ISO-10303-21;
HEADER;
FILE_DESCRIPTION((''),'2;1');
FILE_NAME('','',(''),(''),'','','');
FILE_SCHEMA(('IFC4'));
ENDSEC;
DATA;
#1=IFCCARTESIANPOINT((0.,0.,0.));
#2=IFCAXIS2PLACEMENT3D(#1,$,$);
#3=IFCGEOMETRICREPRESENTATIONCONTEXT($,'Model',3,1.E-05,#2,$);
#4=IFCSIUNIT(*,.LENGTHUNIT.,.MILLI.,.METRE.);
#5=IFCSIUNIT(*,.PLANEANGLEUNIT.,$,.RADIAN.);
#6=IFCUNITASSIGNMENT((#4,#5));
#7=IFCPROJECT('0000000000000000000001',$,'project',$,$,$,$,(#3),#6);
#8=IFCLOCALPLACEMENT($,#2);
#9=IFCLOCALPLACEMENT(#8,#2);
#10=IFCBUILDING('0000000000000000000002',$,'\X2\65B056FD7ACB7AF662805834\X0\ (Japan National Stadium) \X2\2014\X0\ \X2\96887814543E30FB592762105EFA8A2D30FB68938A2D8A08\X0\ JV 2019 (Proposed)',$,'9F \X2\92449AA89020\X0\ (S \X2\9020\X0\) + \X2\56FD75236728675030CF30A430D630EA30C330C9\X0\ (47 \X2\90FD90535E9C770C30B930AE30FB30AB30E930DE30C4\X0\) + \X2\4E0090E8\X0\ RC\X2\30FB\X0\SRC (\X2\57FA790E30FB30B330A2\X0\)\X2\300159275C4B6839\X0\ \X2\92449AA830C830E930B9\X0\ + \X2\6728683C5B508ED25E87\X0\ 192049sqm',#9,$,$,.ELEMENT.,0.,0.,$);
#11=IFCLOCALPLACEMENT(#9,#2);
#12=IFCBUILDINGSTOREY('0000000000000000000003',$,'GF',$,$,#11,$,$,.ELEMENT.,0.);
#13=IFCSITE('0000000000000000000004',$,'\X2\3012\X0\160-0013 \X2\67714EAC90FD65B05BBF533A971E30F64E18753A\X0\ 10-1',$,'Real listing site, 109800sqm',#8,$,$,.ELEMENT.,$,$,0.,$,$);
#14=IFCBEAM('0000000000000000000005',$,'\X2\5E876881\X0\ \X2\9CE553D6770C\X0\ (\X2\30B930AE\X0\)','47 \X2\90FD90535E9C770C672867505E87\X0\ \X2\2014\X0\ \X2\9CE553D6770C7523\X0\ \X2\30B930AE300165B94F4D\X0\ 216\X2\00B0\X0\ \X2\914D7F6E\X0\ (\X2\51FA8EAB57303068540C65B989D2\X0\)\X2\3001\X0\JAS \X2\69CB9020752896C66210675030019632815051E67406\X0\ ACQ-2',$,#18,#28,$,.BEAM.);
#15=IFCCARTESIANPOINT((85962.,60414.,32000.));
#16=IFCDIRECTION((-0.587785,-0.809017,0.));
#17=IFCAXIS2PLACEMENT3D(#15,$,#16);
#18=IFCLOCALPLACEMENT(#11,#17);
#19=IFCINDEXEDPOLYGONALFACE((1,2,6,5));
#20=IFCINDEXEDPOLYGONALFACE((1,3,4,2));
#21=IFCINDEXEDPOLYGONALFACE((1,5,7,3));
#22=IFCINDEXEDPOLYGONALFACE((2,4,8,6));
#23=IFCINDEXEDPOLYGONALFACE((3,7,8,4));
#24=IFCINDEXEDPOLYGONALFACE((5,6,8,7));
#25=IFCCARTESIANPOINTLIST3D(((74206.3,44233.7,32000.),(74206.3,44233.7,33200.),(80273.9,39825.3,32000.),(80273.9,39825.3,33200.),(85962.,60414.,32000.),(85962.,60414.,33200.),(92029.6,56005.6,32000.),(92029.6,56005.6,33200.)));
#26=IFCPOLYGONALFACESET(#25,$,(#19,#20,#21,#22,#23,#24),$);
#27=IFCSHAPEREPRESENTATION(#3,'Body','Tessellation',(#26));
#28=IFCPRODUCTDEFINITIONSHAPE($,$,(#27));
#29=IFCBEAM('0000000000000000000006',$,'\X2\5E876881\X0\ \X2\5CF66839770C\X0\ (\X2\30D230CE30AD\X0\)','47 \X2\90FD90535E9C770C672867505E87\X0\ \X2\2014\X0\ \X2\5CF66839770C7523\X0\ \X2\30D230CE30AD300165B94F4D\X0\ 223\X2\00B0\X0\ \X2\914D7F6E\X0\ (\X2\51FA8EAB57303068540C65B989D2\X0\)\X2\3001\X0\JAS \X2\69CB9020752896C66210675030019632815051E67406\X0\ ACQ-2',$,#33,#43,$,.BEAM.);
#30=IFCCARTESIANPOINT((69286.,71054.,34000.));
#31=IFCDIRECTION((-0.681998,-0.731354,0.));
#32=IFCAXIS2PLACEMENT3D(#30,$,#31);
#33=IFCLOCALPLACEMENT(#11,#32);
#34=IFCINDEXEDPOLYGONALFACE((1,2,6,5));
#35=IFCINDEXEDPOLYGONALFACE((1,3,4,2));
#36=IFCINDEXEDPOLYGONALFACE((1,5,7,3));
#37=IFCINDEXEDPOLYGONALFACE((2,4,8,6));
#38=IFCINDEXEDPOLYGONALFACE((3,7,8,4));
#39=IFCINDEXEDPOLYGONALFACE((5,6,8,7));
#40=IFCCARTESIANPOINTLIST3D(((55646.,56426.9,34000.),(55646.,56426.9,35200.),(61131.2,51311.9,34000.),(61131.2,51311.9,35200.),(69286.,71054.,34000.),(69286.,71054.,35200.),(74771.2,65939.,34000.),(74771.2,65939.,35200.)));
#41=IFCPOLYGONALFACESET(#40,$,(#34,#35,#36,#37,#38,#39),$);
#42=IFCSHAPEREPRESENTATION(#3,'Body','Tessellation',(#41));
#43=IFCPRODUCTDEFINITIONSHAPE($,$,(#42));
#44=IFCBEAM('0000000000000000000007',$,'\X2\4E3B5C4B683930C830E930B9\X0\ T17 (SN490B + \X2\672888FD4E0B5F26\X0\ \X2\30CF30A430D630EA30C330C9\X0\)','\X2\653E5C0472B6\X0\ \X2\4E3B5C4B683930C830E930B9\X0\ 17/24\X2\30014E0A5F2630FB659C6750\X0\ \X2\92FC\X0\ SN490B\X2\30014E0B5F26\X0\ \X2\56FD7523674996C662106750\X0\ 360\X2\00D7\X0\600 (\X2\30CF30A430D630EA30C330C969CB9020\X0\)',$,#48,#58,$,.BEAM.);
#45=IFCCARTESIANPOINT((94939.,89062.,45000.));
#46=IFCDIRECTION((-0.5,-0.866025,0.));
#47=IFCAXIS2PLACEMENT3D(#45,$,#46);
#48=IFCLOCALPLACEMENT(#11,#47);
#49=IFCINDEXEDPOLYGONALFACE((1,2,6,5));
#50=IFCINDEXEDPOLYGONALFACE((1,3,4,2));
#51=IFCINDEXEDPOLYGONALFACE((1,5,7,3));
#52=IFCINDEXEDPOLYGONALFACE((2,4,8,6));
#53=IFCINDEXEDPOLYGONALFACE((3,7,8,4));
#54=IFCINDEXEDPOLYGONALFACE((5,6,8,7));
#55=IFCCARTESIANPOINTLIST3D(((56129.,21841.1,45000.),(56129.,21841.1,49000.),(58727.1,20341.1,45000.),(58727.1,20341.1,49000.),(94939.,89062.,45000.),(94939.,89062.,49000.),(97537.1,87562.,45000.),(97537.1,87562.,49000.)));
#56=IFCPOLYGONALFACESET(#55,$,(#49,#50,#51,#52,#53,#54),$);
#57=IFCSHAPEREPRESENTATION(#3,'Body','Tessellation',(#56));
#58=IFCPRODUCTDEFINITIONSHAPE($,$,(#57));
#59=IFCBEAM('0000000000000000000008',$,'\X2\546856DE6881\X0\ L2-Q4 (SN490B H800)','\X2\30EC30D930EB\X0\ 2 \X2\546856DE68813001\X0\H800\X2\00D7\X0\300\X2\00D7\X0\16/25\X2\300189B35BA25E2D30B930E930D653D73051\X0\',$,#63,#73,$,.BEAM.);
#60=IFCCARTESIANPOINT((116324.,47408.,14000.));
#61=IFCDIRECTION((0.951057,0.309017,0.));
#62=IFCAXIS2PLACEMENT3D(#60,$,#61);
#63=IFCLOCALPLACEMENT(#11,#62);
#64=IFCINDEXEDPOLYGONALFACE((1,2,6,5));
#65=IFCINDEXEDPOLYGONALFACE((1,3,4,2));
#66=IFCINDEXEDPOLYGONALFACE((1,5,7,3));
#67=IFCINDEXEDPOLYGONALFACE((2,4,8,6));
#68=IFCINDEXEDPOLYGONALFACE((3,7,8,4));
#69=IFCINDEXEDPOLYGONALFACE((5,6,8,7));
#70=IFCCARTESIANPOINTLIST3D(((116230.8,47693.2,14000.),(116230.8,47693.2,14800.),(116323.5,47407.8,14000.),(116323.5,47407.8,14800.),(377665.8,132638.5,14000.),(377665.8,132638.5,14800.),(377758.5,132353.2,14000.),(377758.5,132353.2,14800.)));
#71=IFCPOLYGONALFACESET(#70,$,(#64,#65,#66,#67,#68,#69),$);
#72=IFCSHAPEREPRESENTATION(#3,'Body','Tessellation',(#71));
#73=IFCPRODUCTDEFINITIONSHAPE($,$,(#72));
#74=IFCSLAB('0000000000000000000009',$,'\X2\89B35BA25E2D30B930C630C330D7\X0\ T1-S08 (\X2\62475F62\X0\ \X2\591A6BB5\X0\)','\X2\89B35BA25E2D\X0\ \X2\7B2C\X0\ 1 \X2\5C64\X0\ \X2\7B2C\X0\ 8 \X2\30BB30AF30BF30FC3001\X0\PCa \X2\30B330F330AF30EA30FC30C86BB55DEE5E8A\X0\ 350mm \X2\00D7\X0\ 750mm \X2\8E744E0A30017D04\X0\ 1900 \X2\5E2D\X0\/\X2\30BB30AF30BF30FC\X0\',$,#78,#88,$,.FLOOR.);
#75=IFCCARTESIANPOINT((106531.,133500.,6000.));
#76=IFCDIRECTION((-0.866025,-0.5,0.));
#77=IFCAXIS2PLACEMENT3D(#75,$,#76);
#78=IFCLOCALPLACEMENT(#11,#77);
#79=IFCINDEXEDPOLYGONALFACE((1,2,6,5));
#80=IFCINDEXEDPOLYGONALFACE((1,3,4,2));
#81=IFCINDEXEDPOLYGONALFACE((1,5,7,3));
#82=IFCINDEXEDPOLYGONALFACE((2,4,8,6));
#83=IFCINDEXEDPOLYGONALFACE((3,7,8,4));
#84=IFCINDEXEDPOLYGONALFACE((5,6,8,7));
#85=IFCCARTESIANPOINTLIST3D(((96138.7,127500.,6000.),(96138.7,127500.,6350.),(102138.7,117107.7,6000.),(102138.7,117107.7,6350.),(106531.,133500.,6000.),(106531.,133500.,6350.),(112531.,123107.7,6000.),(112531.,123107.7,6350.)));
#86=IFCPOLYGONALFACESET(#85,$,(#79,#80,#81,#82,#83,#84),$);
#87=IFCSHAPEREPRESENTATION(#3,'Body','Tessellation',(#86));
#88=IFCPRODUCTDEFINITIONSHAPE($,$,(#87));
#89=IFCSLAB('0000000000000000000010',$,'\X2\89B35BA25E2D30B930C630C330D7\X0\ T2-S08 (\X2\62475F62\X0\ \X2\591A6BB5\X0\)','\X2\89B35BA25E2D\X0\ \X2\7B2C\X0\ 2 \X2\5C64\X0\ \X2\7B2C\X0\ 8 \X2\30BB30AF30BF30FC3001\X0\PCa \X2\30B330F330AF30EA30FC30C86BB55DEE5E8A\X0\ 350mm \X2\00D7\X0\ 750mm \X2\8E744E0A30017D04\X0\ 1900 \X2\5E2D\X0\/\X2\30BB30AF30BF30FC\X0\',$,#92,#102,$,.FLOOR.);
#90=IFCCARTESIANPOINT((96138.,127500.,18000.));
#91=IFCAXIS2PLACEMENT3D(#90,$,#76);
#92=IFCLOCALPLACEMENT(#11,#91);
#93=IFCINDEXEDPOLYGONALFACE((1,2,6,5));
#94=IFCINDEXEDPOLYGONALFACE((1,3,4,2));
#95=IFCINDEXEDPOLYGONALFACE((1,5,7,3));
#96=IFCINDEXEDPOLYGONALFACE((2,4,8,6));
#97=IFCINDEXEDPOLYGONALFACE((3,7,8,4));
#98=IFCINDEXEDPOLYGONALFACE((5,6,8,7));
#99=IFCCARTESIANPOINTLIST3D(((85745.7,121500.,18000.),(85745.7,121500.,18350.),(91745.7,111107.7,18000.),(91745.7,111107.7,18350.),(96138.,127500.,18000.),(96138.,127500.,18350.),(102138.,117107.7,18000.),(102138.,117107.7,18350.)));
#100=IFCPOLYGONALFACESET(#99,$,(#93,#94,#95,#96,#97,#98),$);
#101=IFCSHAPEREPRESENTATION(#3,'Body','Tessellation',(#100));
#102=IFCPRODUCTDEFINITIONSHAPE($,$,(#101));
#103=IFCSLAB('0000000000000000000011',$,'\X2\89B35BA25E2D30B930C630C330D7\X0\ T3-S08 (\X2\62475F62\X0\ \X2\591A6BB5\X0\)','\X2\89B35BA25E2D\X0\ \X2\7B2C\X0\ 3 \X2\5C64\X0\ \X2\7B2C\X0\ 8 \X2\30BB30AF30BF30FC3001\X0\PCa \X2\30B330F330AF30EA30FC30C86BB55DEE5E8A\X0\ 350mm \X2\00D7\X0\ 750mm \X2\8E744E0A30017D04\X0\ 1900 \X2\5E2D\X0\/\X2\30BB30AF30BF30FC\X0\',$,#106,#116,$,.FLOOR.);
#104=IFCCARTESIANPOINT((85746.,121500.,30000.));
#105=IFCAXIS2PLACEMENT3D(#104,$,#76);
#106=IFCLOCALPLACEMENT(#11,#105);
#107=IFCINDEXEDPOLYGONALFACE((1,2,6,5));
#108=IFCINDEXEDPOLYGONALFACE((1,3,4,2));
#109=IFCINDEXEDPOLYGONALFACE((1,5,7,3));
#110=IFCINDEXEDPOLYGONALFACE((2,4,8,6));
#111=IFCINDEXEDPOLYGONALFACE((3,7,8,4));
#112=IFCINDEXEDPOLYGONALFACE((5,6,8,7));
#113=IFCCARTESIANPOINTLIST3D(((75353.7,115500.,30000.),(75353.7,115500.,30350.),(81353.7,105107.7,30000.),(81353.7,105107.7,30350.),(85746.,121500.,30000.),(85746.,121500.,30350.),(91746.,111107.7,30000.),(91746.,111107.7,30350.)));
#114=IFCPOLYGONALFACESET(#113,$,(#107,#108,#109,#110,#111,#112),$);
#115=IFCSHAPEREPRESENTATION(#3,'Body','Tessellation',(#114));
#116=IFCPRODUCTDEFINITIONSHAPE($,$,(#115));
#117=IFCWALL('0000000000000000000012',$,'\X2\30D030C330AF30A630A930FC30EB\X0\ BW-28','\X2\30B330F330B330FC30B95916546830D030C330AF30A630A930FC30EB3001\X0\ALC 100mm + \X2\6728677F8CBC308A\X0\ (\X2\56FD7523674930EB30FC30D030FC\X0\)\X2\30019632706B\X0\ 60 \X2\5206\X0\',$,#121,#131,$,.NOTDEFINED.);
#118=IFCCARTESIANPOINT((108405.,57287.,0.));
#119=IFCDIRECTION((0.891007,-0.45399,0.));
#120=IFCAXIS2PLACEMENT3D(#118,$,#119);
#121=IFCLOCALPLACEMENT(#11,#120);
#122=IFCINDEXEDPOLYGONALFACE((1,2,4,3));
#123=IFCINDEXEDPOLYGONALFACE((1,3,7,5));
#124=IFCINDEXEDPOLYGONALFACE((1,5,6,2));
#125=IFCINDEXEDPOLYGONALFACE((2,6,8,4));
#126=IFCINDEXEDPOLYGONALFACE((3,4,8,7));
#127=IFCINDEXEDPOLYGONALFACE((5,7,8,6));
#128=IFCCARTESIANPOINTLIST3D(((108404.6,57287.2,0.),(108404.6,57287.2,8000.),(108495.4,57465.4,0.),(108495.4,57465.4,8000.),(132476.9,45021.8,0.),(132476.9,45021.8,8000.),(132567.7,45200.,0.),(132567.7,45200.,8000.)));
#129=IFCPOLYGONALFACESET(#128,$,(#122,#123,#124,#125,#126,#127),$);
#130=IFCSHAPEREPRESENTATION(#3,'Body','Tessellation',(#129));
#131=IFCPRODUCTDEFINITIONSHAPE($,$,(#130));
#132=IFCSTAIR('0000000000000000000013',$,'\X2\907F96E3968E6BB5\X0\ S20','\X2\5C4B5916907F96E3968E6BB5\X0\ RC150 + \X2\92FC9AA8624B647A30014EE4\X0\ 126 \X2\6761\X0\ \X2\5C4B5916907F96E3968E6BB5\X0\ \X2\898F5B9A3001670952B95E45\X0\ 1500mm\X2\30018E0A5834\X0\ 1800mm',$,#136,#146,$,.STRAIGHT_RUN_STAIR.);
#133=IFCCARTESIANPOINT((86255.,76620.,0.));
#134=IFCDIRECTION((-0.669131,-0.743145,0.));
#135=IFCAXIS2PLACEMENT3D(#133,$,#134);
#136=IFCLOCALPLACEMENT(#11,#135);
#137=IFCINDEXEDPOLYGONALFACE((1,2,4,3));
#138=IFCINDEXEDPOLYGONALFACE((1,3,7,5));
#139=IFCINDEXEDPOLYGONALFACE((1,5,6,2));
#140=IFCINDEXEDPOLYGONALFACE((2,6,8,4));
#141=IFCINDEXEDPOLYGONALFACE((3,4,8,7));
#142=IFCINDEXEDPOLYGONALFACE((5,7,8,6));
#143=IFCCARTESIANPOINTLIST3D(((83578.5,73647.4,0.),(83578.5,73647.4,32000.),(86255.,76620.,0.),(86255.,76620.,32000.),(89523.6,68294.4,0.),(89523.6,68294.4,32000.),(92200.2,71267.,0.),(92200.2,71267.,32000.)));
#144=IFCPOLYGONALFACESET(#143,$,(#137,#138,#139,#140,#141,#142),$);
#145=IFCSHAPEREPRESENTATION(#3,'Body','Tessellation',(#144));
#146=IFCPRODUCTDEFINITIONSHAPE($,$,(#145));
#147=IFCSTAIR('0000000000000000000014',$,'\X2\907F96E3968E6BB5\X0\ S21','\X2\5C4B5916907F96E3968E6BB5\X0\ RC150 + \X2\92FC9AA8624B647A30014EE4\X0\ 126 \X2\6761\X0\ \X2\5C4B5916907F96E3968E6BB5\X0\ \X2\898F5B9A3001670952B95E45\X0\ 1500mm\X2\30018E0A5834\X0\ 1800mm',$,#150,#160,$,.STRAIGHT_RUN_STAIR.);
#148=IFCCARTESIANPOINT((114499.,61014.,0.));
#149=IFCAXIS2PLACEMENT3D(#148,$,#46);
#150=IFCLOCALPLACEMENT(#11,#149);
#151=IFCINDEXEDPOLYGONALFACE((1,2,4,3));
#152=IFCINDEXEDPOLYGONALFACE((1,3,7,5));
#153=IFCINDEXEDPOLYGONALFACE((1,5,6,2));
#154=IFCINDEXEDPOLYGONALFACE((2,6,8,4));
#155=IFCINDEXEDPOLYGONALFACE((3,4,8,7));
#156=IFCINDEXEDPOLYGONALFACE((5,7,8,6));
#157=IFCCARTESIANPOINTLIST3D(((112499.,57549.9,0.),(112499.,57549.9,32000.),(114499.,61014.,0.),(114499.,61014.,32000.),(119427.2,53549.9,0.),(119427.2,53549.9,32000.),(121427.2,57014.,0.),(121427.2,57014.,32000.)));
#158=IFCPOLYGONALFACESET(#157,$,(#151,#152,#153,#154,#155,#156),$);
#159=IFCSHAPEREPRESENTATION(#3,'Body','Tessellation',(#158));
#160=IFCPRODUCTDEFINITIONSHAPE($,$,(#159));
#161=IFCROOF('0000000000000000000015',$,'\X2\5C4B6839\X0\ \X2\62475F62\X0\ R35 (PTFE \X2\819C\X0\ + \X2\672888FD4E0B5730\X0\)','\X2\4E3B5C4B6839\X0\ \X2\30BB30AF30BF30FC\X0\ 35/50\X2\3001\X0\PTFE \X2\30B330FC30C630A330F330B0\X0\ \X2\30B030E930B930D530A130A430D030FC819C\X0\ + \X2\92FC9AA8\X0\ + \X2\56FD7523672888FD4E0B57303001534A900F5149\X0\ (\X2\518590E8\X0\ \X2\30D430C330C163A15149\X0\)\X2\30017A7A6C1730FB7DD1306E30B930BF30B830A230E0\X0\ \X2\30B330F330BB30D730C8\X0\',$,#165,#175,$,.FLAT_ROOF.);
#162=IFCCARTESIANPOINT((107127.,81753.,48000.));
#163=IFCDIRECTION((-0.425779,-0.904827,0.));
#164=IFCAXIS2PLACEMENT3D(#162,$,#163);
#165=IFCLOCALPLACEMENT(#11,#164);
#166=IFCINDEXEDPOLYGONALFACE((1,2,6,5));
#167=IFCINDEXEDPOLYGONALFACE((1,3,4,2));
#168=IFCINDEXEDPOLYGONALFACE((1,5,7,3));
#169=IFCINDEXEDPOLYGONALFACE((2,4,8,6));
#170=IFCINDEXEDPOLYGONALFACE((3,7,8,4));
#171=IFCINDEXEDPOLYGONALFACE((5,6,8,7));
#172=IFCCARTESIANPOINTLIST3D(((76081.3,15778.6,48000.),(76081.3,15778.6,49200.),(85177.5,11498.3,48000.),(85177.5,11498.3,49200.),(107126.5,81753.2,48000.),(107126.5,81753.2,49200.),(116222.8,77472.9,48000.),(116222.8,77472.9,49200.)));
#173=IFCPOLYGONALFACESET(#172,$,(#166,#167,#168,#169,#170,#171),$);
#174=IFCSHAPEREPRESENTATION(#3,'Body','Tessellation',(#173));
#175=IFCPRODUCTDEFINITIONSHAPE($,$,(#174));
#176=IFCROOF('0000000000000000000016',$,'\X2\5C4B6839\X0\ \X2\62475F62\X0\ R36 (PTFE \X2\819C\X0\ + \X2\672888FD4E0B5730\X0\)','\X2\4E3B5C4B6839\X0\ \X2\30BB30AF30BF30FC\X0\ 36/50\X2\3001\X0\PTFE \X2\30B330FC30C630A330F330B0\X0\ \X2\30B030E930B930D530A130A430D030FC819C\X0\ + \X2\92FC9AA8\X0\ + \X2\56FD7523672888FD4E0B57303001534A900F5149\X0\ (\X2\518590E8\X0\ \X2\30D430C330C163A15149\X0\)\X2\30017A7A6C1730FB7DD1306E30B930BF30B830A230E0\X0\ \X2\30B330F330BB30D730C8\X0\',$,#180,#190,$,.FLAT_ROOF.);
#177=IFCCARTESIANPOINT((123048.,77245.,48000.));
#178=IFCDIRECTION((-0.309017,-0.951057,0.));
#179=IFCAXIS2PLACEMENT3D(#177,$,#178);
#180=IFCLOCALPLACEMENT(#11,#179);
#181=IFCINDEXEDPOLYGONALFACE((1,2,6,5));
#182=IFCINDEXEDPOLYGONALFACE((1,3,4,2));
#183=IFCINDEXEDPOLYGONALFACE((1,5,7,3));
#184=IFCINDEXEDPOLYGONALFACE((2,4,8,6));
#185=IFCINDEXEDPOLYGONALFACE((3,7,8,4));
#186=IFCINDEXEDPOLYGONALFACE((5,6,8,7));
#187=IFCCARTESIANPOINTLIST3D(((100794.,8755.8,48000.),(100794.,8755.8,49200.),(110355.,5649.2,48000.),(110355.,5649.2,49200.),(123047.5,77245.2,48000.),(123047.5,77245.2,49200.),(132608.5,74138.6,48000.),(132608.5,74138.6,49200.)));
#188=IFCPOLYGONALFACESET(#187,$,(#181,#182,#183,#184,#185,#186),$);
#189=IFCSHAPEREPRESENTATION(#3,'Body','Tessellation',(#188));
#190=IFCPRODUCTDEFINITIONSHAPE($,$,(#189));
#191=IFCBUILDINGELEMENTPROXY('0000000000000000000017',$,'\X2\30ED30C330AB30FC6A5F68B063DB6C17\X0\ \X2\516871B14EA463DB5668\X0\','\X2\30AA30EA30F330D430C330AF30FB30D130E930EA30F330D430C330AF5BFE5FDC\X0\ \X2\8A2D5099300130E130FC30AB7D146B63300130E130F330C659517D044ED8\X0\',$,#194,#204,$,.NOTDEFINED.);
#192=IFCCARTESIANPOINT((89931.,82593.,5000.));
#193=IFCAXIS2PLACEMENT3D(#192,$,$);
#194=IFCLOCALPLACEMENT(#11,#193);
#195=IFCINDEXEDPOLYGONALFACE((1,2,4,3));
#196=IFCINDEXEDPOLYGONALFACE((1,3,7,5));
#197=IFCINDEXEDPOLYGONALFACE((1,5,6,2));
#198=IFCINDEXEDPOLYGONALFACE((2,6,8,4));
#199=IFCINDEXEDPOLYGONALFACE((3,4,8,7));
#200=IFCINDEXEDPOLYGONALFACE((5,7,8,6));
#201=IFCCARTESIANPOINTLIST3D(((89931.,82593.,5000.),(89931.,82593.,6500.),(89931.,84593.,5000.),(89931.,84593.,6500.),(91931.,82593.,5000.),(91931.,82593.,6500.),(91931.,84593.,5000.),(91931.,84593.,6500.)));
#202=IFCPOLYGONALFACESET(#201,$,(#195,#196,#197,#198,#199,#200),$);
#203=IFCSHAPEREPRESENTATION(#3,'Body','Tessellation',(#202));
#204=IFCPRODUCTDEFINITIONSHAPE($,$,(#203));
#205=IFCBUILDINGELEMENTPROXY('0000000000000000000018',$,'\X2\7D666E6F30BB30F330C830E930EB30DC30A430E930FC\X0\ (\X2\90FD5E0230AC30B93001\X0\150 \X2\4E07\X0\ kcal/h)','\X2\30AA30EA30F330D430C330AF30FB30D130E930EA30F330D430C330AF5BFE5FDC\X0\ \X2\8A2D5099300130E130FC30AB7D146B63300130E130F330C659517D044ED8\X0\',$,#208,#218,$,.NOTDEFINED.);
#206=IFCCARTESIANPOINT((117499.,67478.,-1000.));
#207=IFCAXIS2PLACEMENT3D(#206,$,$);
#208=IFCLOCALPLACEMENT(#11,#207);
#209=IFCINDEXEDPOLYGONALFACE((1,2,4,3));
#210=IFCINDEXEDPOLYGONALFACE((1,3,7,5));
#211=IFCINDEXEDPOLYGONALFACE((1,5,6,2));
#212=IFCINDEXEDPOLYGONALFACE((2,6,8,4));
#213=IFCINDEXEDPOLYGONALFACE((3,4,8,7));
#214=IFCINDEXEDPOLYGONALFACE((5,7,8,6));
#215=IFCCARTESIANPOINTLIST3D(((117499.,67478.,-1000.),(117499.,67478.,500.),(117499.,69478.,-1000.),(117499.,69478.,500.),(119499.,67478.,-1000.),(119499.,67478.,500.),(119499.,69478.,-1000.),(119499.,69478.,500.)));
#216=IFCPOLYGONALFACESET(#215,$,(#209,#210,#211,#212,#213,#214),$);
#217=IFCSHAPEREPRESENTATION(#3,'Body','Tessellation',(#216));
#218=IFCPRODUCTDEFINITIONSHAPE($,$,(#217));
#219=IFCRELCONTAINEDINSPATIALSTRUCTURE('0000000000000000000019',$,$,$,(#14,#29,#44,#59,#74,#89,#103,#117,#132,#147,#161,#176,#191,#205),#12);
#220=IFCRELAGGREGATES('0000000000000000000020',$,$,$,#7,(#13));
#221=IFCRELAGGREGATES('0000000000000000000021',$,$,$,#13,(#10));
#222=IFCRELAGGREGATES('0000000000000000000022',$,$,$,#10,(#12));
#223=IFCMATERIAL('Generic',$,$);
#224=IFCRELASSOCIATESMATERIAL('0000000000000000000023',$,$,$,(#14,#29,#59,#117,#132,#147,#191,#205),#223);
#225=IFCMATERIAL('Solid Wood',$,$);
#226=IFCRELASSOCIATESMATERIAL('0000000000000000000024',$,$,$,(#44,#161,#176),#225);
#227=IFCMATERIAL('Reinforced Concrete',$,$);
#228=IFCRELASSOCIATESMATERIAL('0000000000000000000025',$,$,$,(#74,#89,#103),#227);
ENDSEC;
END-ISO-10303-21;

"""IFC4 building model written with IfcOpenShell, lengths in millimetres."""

from ifc_helpers import new_model, si_unit, frame, frame_2d, origin, place, context, project, spatial, rectangle, extrude, material, element, save


model = new_model("IFC4")

# Units and contexts
model_context = context("Model", 3, precision=1e-05, world=origin())
ifc_project = project(units=[si_unit("LENGTHUNIT", "METRE", prefix="MILLI"), si_unit("PLANEANGLEUNIT", "RADIAN")], contexts=[model_context])

# Site, building, storey
site_placement = place(None, origin())
site = spatial("IfcSite", under=ifc_project, at=site_placement, Name="〒160-0013 東京都新宿区霞ヶ丘町 10-1", ObjectType="Real listing site, 109800sqm", CompositionType="ELEMENT", RefElevation=0.0)
building_placement = place(site_placement, origin())
building = spatial("IfcBuilding", under=site, at=building_placement, Name="新国立競技場 (Japan National Stadium) — 隈研吾・大成建設・梓設計 JV 2019 (Proposed)", ObjectType="9F 鉄骨造 (S 造) + 国産木材ハイブリッド (47 都道府県スギ・カラマツ) + 一部 RC・SRC (基礎・コア)、大屋根 鉄骨トラス + 木格子軒庇 192049sqm", CompositionType="ELEMENT", ElevationOfRefHeight=0.0, ElevationOfTerrain=0.0)
storey_placement = place(building_placement, origin())
storey = spatial("IfcBuildingStorey", under=building, at=storey_placement, Name="GF", CompositionType="ELEMENT", Elevation=0.0)

# Shared definitions
ifc_material_1 = material(Name="Reinforced Concrete")

# Shared definitions
ifc_material_2 = material(Name="Generic")

# Beams
beam_1_placement = place(storey_placement, frame((85962.0, 60414.0, 32000.0), x_axis=(-0.587785, -0.809017, 0.0)))
element("IfcBeam", 1, at=beam_1_placement, inside=storey, material=ifc_material_2, Name="庇梁 鳥取県 (スギ)", Description="47 都道府県木材庇 — 鳥取県産 スギ、方位 216° 配置 (出身地と同方角)、JAS 構造用集成材、防腐処理 ACQ-2", PredefinedType="BEAM", context=model_context, shape_type="SweptSolid", body=[
    extrude(rectangle(XDim=20000.0, YDim=7500.0, at=frame_2d((10000.0, 3750.0))), frame((85962.0, 60414.0, 32000.0), x_axis=(-0.587785, -0.809017, 0.0)), (0.0, 0.0, 1.0), 1200.0),
])
beam_2_placement = place(storey_placement, frame((69286.0, 71054.0, 34000.0), x_axis=(-0.681998, -0.731354, 0.0)))
element("IfcBeam", 2, at=beam_2_placement, inside=storey, material=ifc_material_2, Name="庇梁 島根県 (ヒノキ)", Description="47 都道府県木材庇 — 島根県産 ヒノキ、方位 223° 配置 (出身地と同方角)、JAS 構造用集成材、防腐処理 ACQ-2", PredefinedType="BEAM", context=model_context, shape_type="SweptSolid", body=[
    extrude(rectangle(XDim=20000.0, YDim=7500.0, at=frame_2d((10000.0, 3750.0))), frame((69286.0, 71054.0, 34000.0), x_axis=(-0.681998, -0.731354, 0.0)), (0.0, 0.0, 1.0), 1200.0),
])
ifc_material_3 = material(Name="Solid Wood")
beam_3_placement = place(storey_placement, frame((94939.0, 89062.0, 45000.0), x_axis=(-0.5, -0.866025, 0.0)))
element("IfcBeam", 3, at=beam_3_placement, inside=storey, material=ifc_material_3, Name="主屋根トラス T17 (SN490B + 木製下弦 ハイブリッド)", Description="放射状 主屋根トラス 17/24、上弦・斜材 鋼 SN490B、下弦 国産杉集成材 360×600 (ハイブリッド構造)", PredefinedType="BEAM", context=model_context, shape_type="SweptSolid", body=[
    extrude(rectangle(XDim=77620.0, YDim=3000.0, at=frame_2d((38810.0, 1500.0))), frame((94939.0, 89062.0, 45000.0), x_axis=(-0.5, -0.866025, 0.0)), (0.0, 0.0, 1.0), 4000.0),
])
beam_4_placement = place(storey_placement, frame((116324.0, 47408.0, 14000.0), x_axis=(0.951057, 0.309017, 0.0)))
element("IfcBeam", 4, at=beam_4_placement, inside=storey, material=ifc_material_2, Name="周回梁 L2-Q4 (SN490B H800)", Description="レベル 2 周回梁、H800×300×16/25、観客席スラブ受け", PredefinedType="BEAM", context=model_context, shape_type="SweptSolid", body=[
    extrude(rectangle(XDim=274889.0, YDim=300.0, at=frame_2d((137444.0, 150.0))), frame((116324.0, 47408.0, 14000.0), x_axis=(0.951057, 0.309017, 0.0)), (0.0, 0.0, 1.0), 800.0),
])

# Slabs
slab_1_placement = place(storey_placement, frame((106531.0, 133500.0, 6000.0), x_axis=(-0.866025, -0.5, 0.0)))
element("IfcSlab", 5, at=slab_1_placement, inside=storey, material=ifc_material_1, Name="観客席ステップ T1-S08 (扇形 多段)", Description="観客席 第 1 層 第 8 セクター、PCa コンクリート段差床 350mm × 750mm 蹴上、約 1900 席/セクター", PredefinedType="FLOOR", context=model_context, shape_type="SweptSolid", body=[
    extrude(rectangle(XDim=12000.0, YDim=12000.0, at=frame_2d((6000.0, 6000.0))), frame((106531.0, 133500.0, 6000.0), x_axis=(-0.866025, -0.5, 0.0)), (0.0, 0.0, 1.0), 350.0),
])
slab_2_placement = place(storey_placement, frame((96138.0, 127500.0, 18000.0), x_axis=(-0.866025, -0.5, 0.0)))
element("IfcSlab", 6, at=slab_2_placement, inside=storey, material=ifc_material_1, Name="観客席ステップ T2-S08 (扇形 多段)", Description="観客席 第 2 層 第 8 セクター、PCa コンクリート段差床 350mm × 750mm 蹴上、約 1900 席/セクター", PredefinedType="FLOOR", context=model_context, shape_type="SweptSolid", body=[
    extrude(rectangle(XDim=12000.0, YDim=12000.0, at=frame_2d((6000.0, 6000.0))), frame((96138.0, 127500.0, 18000.0), x_axis=(-0.866025, -0.5, 0.0)), (0.0, 0.0, 1.0), 350.0),
])
slab_3_placement = place(storey_placement, frame((85746.0, 121500.0, 30000.0), x_axis=(-0.866025, -0.5, 0.0)))
element("IfcSlab", 7, at=slab_3_placement, inside=storey, material=ifc_material_1, Name="観客席ステップ T3-S08 (扇形 多段)", Description="観客席 第 3 層 第 8 セクター、PCa コンクリート段差床 350mm × 750mm 蹴上、約 1900 席/セクター", PredefinedType="FLOOR", context=model_context, shape_type="SweptSolid", body=[
    extrude(rectangle(XDim=12000.0, YDim=12000.0, at=frame_2d((6000.0, 6000.0))), frame((85746.0, 121500.0, 30000.0), x_axis=(-0.866025, -0.5, 0.0)), (0.0, 0.0, 1.0), 350.0),
])

# Wall
wall_1_placement = place(storey_placement, frame((108405.0, 57287.0, 0.0), x_axis=(0.891007, -0.45399, 0.0)))
element("IfcWall", 8, at=wall_1_placement, inside=storey, material=ifc_material_2, Name="バックウォール BW-28", Description="コンコース外周バックウォール、ALC 100mm + 木板貼り (国産杉ルーバー)、防火 60 分", PredefinedType="NOTDEFINED", context=model_context, shape_type="SweptSolid", body=[
    extrude(rectangle(XDim=27017.0, YDim=200.0, at=frame_2d((13508.0, 100.0))), frame((108405.0, 57287.0, 0.0), x_axis=(0.891007, -0.45399, 0.0)), (0.0, 0.0, 1.0), 8000.0),
])

# Stairs
stair_1_placement = place(storey_placement, frame((86255.0, 76620.0, 0.0), x_axis=(-0.669131, -0.743145, 0.0)))
element("IfcStair", 9, at=stair_1_placement, inside=storey, material=ifc_material_2, Name="避難階段 S20", Description="屋外避難階段 RC150 + 鋼骨手摺、令 126 条 屋外避難階段 規定、有効幅 1500mm、踊場 1800mm", PredefinedType="STRAIGHT_RUN_STAIR", context=model_context, shape_type="SweptSolid", body=[
    extrude(rectangle(XDim=4000.0, YDim=8000.0, at=frame_2d((2000.0, 4000.0))), frame((86255.0, 76620.0, 0.0), x_axis=(-0.669131, -0.743145, 0.0)), (0.0, 0.0, 1.0), 32000.0),
])
stair_2_placement = place(storey_placement, frame((114499.0, 61014.0, 0.0), x_axis=(-0.5, -0.866025, 0.0)))
element("IfcStair", 10, at=stair_2_placement, inside=storey, material=ifc_material_2, Name="避難階段 S21", Description="屋外避難階段 RC150 + 鋼骨手摺、令 126 条 屋外避難階段 規定、有効幅 1500mm、踊場 1800mm", PredefinedType="STRAIGHT_RUN_STAIR", context=model_context, shape_type="SweptSolid", body=[
    extrude(rectangle(XDim=4000.0, YDim=8000.0, at=frame_2d((2000.0, 4000.0))), frame((114499.0, 61014.0, 0.0), x_axis=(-0.5, -0.866025, 0.0)), (0.0, 0.0, 1.0), 32000.0),
])

# Roofs
roof_1_placement = place(storey_placement, frame((107127.0, 81753.0, 48000.0), x_axis=(-0.425779, -0.904827, 0.0)))
element("IfcRoof", 11, at=roof_1_placement, inside=storey, material=ifc_material_3, Name="屋根 扇形 R35 (PTFE 膜 + 木製下地)", Description="主屋根 セクター 35/50、PTFE コーティング グラスファイバー膜 + 鋼骨 + 国産木製下地、半透光 (内部 ピッチ採光)、空気・緑のスタジアム コンセプト", PredefinedType="FLAT_ROOF", context=model_context, shape_type="SweptSolid", body=[
    extrude(rectangle(XDim=72914.0, YDim=10053.0, at=frame_2d((36457.0, 5026.0))), frame((107127.0, 81753.0, 48000.0), x_axis=(-0.425779, -0.904827, 0.0)), (0.0, 0.0, 1.0), 1200.0),
])
roof_2_placement = place(storey_placement, frame((123048.0, 77245.0, 48000.0), x_axis=(-0.309017, -0.951057, 0.0)))
element("IfcRoof", 12, at=roof_2_placement, inside=storey, material=ifc_material_3, Name="屋根 扇形 R36 (PTFE 膜 + 木製下地)", Description="主屋根 セクター 36/50、PTFE コーティング グラスファイバー膜 + 鋼骨 + 国産木製下地、半透光 (内部 ピッチ採光)、空気・緑のスタジアム コンセプト", PredefinedType="FLAT_ROOF", context=model_context, shape_type="SweptSolid", body=[
    extrude(rectangle(XDim=72014.0, YDim=10053.0, at=frame_2d((36007.0, 5026.0))), frame((123048.0, 77245.0, 48000.0), x_axis=(-0.309017, -0.951057, 0.0)), (0.0, 0.0, 1.0), 1200.0),
])

# Building element proxies
proxy_1_placement = place(storey_placement, frame((89931.0, 82593.0, 5000.0)))
element("IfcBuildingElementProxy", 13, at=proxy_1_placement, inside=storey, material=ifc_material_2, Name="ロッカー機械換気 全熱交換器", Description="オリンピック・パラリンピック対応 設備、メーカ純正、メンテ契約付", PredefinedType="NOTDEFINED", context=model_context, shape_type="SweptSolid", body=[
    extrude(rectangle(XDim=2000.0, YDim=2000.0, at=frame_2d((1000.0, 1000.0))), frame((89931.0, 82593.0, 5000.0)), (0.0, 0.0, 1.0), 1500.0),
])
proxy_2_placement = place(storey_placement, frame((117499.0, 67478.0, -1000.0)))
element("IfcBuildingElementProxy", 14, at=proxy_2_placement, inside=storey, material=ifc_material_2, Name="給湯セントラルボイラー (都市ガス、150 万 kcal/h)", Description="オリンピック・パラリンピック対応 設備、メーカ純正、メンテ契約付", PredefinedType="NOTDEFINED", context=model_context, shape_type="SweptSolid", body=[
    extrude(rectangle(XDim=2000.0, YDim=2000.0, at=frame_2d((1000.0, 1000.0))), frame((117499.0, 67478.0, -1000.0)), (0.0, 0.0, 1.0), 1500.0),
])

save(model, "model.ifc")
